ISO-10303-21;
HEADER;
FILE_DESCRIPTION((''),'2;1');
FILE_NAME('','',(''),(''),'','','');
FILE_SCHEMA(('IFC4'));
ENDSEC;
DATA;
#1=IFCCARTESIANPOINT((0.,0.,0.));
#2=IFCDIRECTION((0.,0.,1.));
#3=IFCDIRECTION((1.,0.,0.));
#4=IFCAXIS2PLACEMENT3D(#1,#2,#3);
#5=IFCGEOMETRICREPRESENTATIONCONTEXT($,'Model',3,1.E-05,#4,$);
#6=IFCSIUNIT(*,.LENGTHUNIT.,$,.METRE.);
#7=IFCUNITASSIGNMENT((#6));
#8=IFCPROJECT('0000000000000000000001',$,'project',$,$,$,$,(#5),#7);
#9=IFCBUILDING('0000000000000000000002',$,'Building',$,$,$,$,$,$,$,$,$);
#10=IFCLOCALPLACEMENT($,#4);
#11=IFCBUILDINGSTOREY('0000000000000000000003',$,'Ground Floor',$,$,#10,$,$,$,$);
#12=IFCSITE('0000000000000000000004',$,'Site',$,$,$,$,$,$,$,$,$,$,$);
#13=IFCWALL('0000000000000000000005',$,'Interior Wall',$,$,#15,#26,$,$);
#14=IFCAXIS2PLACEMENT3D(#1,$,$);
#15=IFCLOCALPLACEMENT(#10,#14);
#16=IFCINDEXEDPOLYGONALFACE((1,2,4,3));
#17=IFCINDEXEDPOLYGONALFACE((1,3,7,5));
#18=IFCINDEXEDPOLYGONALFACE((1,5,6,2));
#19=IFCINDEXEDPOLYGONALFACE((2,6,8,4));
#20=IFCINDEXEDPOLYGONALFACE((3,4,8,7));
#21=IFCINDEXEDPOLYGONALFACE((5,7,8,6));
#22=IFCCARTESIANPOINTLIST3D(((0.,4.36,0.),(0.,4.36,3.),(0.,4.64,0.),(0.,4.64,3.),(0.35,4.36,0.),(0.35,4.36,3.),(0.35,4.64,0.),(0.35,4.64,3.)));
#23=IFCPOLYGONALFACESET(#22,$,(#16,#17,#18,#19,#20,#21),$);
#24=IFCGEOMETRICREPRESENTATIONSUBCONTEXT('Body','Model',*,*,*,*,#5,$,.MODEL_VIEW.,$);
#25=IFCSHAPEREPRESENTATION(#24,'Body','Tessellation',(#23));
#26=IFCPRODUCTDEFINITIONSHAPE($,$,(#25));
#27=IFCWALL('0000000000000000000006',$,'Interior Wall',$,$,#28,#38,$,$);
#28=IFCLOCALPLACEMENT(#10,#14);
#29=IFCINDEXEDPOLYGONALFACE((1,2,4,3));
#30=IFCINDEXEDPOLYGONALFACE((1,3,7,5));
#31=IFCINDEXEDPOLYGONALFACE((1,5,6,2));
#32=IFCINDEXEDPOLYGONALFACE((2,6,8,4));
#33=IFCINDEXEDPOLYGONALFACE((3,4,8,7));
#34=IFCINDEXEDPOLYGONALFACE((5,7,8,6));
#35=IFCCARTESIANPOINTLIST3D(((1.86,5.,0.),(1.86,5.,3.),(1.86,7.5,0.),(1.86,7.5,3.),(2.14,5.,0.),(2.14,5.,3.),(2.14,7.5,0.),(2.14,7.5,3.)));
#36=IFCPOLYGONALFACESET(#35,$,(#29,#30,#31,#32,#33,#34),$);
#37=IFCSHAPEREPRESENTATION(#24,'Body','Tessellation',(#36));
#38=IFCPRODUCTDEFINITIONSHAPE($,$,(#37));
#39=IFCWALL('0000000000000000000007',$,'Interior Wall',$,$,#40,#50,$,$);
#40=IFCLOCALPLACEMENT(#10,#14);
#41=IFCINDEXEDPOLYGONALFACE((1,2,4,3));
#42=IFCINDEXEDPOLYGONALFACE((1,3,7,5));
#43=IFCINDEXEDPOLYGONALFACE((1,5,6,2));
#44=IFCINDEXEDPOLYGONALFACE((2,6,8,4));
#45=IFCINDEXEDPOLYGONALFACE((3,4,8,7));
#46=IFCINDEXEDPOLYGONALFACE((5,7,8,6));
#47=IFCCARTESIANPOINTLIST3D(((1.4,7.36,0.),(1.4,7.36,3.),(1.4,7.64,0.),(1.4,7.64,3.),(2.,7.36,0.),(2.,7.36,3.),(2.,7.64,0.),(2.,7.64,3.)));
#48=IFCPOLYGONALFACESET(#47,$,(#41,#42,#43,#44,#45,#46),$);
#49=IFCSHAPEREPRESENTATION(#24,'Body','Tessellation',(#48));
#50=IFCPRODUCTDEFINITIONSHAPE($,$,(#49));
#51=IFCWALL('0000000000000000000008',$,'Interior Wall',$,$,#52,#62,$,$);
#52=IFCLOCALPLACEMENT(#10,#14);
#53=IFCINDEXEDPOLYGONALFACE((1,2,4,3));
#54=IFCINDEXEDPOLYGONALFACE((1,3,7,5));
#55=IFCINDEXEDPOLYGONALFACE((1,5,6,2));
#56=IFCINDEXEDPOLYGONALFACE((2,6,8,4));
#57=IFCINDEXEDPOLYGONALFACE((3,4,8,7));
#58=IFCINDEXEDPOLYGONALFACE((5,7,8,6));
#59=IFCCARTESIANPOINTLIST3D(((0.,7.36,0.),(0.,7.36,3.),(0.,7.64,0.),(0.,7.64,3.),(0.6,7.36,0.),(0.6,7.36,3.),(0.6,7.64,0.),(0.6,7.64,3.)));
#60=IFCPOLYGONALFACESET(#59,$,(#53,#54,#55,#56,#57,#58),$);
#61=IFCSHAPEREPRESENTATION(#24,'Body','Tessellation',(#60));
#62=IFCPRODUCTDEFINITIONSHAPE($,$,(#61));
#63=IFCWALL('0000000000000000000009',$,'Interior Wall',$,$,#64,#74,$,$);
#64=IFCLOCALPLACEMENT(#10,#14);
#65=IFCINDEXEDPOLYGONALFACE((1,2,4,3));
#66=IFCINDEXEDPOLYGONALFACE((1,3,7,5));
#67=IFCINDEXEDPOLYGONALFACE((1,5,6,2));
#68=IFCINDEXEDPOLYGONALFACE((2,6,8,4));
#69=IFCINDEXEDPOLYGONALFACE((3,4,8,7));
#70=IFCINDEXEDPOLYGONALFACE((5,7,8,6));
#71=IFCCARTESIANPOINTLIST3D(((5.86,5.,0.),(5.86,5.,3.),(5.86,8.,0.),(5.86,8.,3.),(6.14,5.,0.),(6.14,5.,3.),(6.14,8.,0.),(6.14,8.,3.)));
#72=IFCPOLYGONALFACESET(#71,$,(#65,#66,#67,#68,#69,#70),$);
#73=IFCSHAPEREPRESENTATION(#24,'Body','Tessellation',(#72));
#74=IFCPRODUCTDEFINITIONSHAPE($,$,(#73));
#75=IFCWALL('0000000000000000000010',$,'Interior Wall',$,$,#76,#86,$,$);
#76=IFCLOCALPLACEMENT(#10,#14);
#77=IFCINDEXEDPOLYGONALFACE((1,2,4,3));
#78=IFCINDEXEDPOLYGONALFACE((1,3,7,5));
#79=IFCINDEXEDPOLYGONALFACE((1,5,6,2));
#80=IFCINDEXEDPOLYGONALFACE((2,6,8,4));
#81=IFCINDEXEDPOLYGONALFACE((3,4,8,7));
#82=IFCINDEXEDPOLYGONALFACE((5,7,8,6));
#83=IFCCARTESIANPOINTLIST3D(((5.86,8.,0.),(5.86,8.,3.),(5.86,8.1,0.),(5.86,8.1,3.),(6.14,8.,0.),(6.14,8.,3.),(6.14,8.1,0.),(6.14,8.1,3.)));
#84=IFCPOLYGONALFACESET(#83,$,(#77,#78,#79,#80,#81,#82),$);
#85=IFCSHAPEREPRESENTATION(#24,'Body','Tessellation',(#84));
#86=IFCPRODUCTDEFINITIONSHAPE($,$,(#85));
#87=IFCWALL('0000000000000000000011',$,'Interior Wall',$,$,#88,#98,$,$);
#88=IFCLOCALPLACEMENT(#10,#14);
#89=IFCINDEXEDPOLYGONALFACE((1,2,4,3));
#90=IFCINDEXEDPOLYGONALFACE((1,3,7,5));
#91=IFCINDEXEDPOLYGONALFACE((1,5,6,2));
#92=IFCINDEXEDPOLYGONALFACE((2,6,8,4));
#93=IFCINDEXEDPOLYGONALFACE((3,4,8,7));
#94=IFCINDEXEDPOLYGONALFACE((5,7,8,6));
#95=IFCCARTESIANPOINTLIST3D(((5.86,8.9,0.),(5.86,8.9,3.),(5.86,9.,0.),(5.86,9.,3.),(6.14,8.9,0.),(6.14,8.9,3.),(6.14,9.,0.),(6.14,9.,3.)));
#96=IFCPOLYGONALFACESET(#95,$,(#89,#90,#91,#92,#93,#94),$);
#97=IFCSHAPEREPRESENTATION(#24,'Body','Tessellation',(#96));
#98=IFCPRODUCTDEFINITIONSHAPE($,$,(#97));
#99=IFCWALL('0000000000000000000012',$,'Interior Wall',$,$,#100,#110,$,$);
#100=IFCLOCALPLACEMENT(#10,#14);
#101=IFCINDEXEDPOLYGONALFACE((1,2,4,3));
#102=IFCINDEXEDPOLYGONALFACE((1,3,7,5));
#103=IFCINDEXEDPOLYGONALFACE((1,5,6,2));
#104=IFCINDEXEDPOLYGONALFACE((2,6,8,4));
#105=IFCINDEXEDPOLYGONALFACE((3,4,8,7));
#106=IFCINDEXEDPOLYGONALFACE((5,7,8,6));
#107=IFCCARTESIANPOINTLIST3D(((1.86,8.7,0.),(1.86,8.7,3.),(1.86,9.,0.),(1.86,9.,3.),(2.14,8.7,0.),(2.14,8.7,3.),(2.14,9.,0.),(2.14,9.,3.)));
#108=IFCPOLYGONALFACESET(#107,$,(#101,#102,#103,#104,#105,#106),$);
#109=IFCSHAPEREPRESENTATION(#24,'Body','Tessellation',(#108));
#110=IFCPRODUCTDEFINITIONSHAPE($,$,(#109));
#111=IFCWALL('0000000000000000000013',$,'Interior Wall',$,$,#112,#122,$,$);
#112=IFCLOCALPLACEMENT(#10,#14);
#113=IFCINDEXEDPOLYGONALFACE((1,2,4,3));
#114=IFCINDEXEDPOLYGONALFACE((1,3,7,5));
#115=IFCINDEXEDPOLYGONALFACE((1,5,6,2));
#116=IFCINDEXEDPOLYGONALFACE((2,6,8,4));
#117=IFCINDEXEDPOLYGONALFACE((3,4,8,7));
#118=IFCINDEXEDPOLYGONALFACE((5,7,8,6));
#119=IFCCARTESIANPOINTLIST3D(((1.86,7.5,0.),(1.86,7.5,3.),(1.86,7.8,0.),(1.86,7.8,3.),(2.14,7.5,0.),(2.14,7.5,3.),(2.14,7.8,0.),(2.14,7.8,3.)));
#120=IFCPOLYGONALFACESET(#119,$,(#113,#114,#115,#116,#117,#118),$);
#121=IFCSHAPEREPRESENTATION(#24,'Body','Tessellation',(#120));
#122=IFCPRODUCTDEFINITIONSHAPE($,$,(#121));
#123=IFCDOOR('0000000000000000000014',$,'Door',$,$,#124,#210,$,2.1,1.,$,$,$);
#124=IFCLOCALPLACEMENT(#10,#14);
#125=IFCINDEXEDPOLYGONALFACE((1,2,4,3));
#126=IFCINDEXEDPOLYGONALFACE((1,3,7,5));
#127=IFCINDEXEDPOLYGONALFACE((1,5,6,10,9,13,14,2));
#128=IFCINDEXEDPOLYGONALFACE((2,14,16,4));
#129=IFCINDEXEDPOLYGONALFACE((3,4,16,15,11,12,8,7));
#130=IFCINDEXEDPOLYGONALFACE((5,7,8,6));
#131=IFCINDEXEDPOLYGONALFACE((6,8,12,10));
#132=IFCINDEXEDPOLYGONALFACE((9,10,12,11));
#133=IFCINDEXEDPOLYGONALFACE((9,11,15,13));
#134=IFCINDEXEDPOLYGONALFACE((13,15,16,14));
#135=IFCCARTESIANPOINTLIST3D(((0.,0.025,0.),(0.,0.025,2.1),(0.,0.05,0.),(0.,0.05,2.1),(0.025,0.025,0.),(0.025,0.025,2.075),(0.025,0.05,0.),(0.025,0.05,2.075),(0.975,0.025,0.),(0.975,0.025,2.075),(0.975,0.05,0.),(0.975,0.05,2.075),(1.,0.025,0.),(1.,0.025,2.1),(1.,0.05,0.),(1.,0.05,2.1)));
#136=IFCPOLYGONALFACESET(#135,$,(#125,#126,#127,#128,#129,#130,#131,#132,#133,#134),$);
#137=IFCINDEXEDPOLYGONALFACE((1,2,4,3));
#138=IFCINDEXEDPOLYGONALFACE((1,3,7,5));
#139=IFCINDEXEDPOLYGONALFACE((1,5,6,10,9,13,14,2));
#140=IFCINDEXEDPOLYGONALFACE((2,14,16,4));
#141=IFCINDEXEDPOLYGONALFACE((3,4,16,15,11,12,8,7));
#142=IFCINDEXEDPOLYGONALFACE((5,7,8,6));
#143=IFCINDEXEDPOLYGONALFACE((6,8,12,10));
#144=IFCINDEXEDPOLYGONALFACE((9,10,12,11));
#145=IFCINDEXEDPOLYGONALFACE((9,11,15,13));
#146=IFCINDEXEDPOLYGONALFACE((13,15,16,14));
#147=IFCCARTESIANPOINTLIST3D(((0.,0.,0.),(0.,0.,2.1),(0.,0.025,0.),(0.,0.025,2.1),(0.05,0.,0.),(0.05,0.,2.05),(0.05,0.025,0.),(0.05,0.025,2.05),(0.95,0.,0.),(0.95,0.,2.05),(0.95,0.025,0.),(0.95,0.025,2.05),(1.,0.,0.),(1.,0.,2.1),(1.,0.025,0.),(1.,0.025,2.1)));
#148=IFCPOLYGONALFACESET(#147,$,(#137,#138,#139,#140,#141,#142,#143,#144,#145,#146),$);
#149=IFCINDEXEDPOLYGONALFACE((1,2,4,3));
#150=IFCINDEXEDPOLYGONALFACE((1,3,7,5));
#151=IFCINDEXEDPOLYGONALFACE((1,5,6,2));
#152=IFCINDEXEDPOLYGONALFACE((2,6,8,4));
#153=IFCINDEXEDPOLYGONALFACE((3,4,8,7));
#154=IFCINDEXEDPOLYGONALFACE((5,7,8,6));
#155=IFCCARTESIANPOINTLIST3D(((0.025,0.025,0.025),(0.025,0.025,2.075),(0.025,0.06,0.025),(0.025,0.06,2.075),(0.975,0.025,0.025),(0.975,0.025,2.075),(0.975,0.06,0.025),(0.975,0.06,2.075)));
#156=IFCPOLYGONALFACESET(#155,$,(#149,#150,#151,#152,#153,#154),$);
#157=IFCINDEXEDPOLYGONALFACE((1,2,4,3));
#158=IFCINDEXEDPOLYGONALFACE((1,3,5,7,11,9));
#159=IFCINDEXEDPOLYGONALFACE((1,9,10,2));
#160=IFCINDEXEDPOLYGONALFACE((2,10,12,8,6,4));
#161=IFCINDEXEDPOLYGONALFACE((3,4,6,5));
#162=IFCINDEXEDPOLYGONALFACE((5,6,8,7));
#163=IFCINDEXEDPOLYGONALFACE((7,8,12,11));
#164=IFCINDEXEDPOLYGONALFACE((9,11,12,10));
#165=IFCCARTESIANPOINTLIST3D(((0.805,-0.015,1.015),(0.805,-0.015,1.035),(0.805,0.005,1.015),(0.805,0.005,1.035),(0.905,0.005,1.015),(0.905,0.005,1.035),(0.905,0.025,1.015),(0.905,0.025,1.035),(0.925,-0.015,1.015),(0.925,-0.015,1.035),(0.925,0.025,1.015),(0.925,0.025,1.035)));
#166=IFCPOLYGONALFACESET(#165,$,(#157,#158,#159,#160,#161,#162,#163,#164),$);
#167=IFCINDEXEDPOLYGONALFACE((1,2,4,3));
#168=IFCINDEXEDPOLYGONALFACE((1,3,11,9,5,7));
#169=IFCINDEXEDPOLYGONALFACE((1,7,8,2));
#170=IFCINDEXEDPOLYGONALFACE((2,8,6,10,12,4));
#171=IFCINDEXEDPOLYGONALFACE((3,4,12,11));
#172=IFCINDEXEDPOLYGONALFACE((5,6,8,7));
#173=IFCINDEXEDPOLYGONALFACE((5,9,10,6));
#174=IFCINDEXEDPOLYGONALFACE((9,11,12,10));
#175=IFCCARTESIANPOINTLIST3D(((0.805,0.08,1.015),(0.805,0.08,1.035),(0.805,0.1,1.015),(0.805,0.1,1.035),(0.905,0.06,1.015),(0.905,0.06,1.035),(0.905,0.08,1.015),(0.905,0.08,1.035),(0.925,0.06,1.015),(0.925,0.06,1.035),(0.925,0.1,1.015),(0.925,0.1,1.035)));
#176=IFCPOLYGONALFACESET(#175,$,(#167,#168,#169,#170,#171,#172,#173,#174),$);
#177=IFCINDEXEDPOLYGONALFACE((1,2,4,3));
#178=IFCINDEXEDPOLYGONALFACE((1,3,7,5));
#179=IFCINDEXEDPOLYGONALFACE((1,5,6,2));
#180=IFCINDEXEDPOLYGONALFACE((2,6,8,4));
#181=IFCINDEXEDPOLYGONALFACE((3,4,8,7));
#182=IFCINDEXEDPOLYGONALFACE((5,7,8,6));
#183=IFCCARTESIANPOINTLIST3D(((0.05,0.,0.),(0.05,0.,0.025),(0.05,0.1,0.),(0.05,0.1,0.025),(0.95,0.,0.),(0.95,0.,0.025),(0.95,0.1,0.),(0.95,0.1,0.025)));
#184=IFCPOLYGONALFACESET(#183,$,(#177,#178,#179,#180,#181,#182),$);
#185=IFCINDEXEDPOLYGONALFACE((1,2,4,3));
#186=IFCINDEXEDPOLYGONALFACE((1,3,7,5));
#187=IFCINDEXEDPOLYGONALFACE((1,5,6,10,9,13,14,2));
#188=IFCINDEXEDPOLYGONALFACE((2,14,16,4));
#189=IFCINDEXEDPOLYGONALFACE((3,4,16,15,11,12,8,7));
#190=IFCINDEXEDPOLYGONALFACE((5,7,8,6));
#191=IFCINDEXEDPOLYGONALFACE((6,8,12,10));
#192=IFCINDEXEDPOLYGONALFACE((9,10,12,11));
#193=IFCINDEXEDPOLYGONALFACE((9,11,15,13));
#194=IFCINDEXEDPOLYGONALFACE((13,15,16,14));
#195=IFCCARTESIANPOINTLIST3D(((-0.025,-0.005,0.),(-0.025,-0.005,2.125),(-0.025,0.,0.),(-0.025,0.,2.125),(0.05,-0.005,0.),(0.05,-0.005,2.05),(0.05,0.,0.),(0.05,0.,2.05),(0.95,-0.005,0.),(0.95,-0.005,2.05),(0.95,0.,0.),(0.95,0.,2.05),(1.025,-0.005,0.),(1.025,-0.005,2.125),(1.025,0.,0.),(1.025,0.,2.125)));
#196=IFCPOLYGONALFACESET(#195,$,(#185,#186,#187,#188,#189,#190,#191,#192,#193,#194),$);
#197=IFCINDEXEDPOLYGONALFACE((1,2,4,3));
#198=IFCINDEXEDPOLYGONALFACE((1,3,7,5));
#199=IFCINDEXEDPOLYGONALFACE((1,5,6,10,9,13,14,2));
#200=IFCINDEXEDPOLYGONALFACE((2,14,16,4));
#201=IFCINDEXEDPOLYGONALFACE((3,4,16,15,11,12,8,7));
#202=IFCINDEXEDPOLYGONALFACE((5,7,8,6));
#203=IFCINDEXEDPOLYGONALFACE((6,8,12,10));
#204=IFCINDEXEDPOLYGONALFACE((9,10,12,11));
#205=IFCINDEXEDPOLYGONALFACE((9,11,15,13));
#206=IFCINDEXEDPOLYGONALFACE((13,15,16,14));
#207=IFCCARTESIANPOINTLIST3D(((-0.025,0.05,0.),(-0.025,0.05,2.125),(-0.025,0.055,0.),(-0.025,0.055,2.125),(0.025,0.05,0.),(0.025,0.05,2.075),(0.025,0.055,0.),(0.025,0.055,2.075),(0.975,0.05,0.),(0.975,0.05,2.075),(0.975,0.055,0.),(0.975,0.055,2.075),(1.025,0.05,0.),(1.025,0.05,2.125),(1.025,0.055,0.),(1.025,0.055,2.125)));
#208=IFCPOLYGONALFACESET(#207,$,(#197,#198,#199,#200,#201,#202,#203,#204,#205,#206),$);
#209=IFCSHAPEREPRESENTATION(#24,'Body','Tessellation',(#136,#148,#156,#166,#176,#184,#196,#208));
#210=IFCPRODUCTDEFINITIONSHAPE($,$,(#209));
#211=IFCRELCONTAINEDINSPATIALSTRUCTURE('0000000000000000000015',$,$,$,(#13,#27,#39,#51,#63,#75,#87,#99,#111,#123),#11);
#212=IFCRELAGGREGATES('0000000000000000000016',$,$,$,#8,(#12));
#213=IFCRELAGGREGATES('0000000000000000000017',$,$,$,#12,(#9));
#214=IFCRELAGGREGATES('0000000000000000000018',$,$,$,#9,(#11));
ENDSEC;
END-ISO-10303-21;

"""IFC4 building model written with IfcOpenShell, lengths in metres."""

from ifc_helpers import new_model, si_unit, frame, origin_with_axes, place, context, subcontext, project, spatial, line, indexed_curve, outline, extrude, element, save


model = new_model("IFC4")

# Units and contexts
model_context = context("Model", 3, precision=1e-05, world=origin_with_axes())
body_context = subcontext(model_context, "Body", "Model", "MODEL_VIEW")
ifc_project = project(units=[si_unit("LENGTHUNIT", "METRE")], contexts=[model_context])

# Site, building, storey
site = spatial("IfcSite", under=ifc_project, Name="Site")
building = spatial("IfcBuilding", under=site, Name="Building")
storey_placement = place(None, origin_with_axes())
storey = spatial("IfcBuildingStorey", under=building, at=storey_placement, Name="Ground Floor")

# Walls
wall_1_placement = place(storey_placement, frame((0.35, 4.5, 0.0), z_axis=(0.0, 0.0, 1.0), x_axis=(-1.0, 0.0, 0.0)))
element("IfcWall", 1, at=wall_1_placement, inside=storey, Name="Interior Wall", context=body_context, shape_type="SweptSolid", body=[
    extrude(outline(indexed_curve([(0.0, 0.0), (0.0, 0.28), (0.35, 0.28), (0.35, 0.0), (0.0, 0.0)], self_intersect=False)), frame((0.0, -0.14, 0.0), z_axis=(0.0, 0.0, 1.0), x_axis=(1.0, 0.0, 0.0)), (0.0, 0.0, 1.0), 3.0),
])
wall_2_placement = place(storey_placement, frame((2.0, 5.0, 0.0), z_axis=(0.0, 0.0, 1.0), x_axis=(0.0, 1.0, 0.0)))
element("IfcWall", 2, at=wall_2_placement, inside=storey, Name="Interior Wall", context=body_context, shape_type="SweptSolid", body=[
    extrude(outline(indexed_curve([(0.0, 0.0), (0.0, 0.28), (2.5, 0.28), (2.5, 0.0), (0.0, 0.0)], self_intersect=False)), frame((0.0, -0.14, 0.0), z_axis=(0.0, 0.0, 1.0), x_axis=(1.0, 0.0, 0.0)), (0.0, 0.0, 1.0), 3.0),
])
for number, where, z_axis, x_axis, name in (
    (3, (2.0, 7.5, 0.0), (0.0, 0.0, 1.0), (-1.0, 0.0, 0.0), "Interior Wall"),
    (4, (0.6, 7.5, 0.0), (0.0, 0.0, 1.0), (-1.0, 0.0, 0.0), "Interior Wall"),
):
    element("IfcWall", number, at=place(storey_placement, frame(where, z_axis=z_axis, x_axis=x_axis)), inside=storey, Name=name, context=body_context, shape_type="SweptSolid", body=[
        extrude(outline(indexed_curve([(0.0, 0.0), (0.0, 0.28), (0.6, 0.28), (0.6, 0.0), (0.0, 0.0)], self_intersect=False)), frame((0.0, -0.14, 0.0), z_axis=(0.0, 0.0, 1.0), x_axis=(1.0, 0.0, 0.0)), (0.0, 0.0, 1.0), 3.0),
    ])
wall_3_placement = place(storey_placement, frame((6.0, 5.0, 0.0), z_axis=(0.0, 0.0, 1.0), x_axis=(0.0, 1.0, 0.0)))
element("IfcWall", 5, at=wall_3_placement, inside=storey, Name="Interior Wall", context=body_context, shape_type="SweptSolid", body=[
    extrude(outline(indexed_curve([(0.0, 0.0), (0.0, 0.28), (3.0, 0.28), (3.0, 0.0), (0.0, 0.0)], self_intersect=False)), frame((0.0, -0.14, 0.0), z_axis=(0.0, 0.0, 1.0), x_axis=(1.0, 0.0, 0.0)), (0.0, 0.0, 1.0), 3.0),
])
for number, where, z_axis, x_axis, name in (
    (6, (6.0, 8.0, 0.0), (0.0, 0.0, 1.0), (0.0, 1.0, 0.0), "Interior Wall"),
    (7, (6.0, 8.9, 0.0), (0.0, 0.0, 1.0), (0.0, 1.0, 0.0), "Interior Wall"),
):
    element("IfcWall", number, at=place(storey_placement, frame(where, z_axis=z_axis, x_axis=x_axis)), inside=storey, Name=name, context=body_context, shape_type="SweptSolid", body=[
        extrude(outline(indexed_curve([(0.0, 0.0), (0.0, 0.28), (0.1, 0.28), (0.1, 0.0), (0.0, 0.0)], self_intersect=False)), frame((0.0, -0.14, 0.0), z_axis=(0.0, 0.0, 1.0), x_axis=(1.0, 0.0, 0.0)), (0.0, 0.0, 1.0), 3.0),
    ])
wall_4_placement = place(storey_placement, frame((2.0, 9.0, 0.0), z_axis=(0.0, 0.0, 1.0), x_axis=(0.0, -1.0, 0.0)))
element("IfcWall", 8, at=wall_4_placement, inside=storey, Name="Interior Wall", context=body_context, shape_type="SweptSolid", body=[
    extrude(outline(indexed_curve([(0.0, 0.0), (0.0, 0.28), (0.3, 0.28), (0.3, 0.0), (0.0, 0.0)], self_intersect=False)), frame((0.0, -0.14, 0.0), z_axis=(0.0, 0.0, 1.0), x_axis=(1.0, 0.0, 0.0)), (0.0, 0.0, 1.0), 3.0),
])
wall_5_placement = place(storey_placement, frame((2.0, 7.8, 0.0), z_axis=(0.0, 0.0, 1.0), x_axis=(0.0, -1.0, 0.0)))
element("IfcWall", 9, at=wall_5_placement, inside=storey, Name="Interior Wall", context=body_context, shape_type="SweptSolid", body=[
    extrude(outline(indexed_curve([(0.0, 0.0), (0.0, 0.28), (0.3, 0.28), (0.3, 0.0), (0.0, 0.0)], self_intersect=False)), frame((0.0, -0.14, 0.0), z_axis=(0.0, 0.0, 1.0), x_axis=(1.0, 0.0, 0.0)), (0.0, 0.0, 1.0), 3.0),
])

# Door
door_1_placement = place(storey_placement, origin_with_axes())
element("IfcDoor", 10, at=door_1_placement, inside=storey, Name="Door", OverallHeight=2.1, OverallWidth=1.0, context=body_context, shape_type="SweptSolid", body=[
    extrude(outline(indexed_curve([(0.0, 0.0), (0.0, 2.1), (1.0, 2.1), (1.0, 0.0), (0.975, 0.0), (0.975, 2.075), (0.025, 2.075), (0.025, 0.0)], segments=[line(1, 2, 3, 4, 5, 6, 7, 8, 1)])), frame((0.0, 0.025, 0.0), z_axis=(0.0, -1.0, 0.0), x_axis=(1.0, 0.0, 0.0)), (0.0, 0.0, -1.0), 0.025),
    extrude(outline(indexed_curve([(0.0, 0.0), (0.0, 2.1), (1.0, 2.1), (1.0, 0.0), (0.95, 0.0), (0.95, 2.05), (0.05, 2.05), (0.05, 0.0)], segments=[line(1, 2, 3, 4, 5, 6, 7, 8, 1)])), frame((0.0, 0.0, 0.0), z_axis=(0.0, -1.0, 0.0), x_axis=(1.0, 0.0, 0.0)), (0.0, 0.0, -1.0), 0.025),
    extrude(outline(indexed_curve([(0.0, 0.0), (0.95, 0.0), (0.95, 0.035), (0.0, 0.035)], segments=[line(1, 2, 3, 4, 1)])), frame((0.025, 0.025, 0.025), z_axis=(0.0, 0.0, 1.0), x_axis=(1.0, 0.0, 0.0)), (0.0, 0.0, 1.0), 2.05),
    extrude(outline(indexed_curve([(0.0, 0.0), (0.0, -0.04), (-0.12, -0.04), (-0.12, -0.02), (-0.02, -0.02), (-0.02, 0.0)], segments=[line(1, 2, 3, 4, 5, 6, 1)])), frame((0.925, 0.025, 1.015), z_axis=(0.0, 0.0, 1.0), x_axis=(1.0, 0.0, 0.0)), (0.0, 0.0, 1.0), 0.02),
    extrude(outline(indexed_curve([(0.0, 0.0), (0.0, 0.04), (-0.12, 0.04), (-0.12, 0.02), (-0.02, 0.02), (-0.02, 0.0)], segments=[line(1, 2, 3, 4, 5, 6, 1)])), frame((0.925, 0.06, 1.015), z_axis=(0.0, 0.0, 1.0), x_axis=(1.0, 0.0, 0.0)), (0.0, 0.0, 1.0), 0.02),
    extrude(outline(indexed_curve([(0.0, 0.0), (0.9, 0.0), (0.9, 0.1), (0.0, 0.1)], segments=[line(1, 2, 3, 4, 1)])), frame((0.05, 0.0, 0.0), z_axis=(0.0, 0.0, 1.0), x_axis=(1.0, 0.0, 0.0)), (0.0, 0.0, 1.0), 0.025),
    extrude(outline(indexed_curve([(0.0, 0.0), (0.0, 2.125), (1.05, 2.125), (1.05, 0.0), (0.975, 0.0), (0.975, 2.05), (0.075, 2.05), (0.075, 0.0)], segments=[line(1, 2, 3, 4, 5, 6, 7, 8, 1)])), frame((-0.025, -0.005, 0.0), z_axis=(0.0, -1.0, 0.0), x_axis=(1.0, 0.0, 0.0)), (0.0, 0.0, -1.0), 0.005),
    extrude(outline(indexed_curve([(0.0, 0.0), (0.0, 2.125), (1.05, 2.125), (1.05, 0.0), (1.0, 0.0), (1.0, 2.075), (0.05, 2.075), (0.05, 0.0)], segments=[line(1, 2, 3, 4, 5, 6, 7, 8, 1)])), frame((-0.025, 0.05, 0.0), z_axis=(0.0, -1.0, 0.0), x_axis=(1.0, 0.0, 0.0)), (0.0, 0.0, -1.0), 0.005),
])

save(model, "model.ifc")
